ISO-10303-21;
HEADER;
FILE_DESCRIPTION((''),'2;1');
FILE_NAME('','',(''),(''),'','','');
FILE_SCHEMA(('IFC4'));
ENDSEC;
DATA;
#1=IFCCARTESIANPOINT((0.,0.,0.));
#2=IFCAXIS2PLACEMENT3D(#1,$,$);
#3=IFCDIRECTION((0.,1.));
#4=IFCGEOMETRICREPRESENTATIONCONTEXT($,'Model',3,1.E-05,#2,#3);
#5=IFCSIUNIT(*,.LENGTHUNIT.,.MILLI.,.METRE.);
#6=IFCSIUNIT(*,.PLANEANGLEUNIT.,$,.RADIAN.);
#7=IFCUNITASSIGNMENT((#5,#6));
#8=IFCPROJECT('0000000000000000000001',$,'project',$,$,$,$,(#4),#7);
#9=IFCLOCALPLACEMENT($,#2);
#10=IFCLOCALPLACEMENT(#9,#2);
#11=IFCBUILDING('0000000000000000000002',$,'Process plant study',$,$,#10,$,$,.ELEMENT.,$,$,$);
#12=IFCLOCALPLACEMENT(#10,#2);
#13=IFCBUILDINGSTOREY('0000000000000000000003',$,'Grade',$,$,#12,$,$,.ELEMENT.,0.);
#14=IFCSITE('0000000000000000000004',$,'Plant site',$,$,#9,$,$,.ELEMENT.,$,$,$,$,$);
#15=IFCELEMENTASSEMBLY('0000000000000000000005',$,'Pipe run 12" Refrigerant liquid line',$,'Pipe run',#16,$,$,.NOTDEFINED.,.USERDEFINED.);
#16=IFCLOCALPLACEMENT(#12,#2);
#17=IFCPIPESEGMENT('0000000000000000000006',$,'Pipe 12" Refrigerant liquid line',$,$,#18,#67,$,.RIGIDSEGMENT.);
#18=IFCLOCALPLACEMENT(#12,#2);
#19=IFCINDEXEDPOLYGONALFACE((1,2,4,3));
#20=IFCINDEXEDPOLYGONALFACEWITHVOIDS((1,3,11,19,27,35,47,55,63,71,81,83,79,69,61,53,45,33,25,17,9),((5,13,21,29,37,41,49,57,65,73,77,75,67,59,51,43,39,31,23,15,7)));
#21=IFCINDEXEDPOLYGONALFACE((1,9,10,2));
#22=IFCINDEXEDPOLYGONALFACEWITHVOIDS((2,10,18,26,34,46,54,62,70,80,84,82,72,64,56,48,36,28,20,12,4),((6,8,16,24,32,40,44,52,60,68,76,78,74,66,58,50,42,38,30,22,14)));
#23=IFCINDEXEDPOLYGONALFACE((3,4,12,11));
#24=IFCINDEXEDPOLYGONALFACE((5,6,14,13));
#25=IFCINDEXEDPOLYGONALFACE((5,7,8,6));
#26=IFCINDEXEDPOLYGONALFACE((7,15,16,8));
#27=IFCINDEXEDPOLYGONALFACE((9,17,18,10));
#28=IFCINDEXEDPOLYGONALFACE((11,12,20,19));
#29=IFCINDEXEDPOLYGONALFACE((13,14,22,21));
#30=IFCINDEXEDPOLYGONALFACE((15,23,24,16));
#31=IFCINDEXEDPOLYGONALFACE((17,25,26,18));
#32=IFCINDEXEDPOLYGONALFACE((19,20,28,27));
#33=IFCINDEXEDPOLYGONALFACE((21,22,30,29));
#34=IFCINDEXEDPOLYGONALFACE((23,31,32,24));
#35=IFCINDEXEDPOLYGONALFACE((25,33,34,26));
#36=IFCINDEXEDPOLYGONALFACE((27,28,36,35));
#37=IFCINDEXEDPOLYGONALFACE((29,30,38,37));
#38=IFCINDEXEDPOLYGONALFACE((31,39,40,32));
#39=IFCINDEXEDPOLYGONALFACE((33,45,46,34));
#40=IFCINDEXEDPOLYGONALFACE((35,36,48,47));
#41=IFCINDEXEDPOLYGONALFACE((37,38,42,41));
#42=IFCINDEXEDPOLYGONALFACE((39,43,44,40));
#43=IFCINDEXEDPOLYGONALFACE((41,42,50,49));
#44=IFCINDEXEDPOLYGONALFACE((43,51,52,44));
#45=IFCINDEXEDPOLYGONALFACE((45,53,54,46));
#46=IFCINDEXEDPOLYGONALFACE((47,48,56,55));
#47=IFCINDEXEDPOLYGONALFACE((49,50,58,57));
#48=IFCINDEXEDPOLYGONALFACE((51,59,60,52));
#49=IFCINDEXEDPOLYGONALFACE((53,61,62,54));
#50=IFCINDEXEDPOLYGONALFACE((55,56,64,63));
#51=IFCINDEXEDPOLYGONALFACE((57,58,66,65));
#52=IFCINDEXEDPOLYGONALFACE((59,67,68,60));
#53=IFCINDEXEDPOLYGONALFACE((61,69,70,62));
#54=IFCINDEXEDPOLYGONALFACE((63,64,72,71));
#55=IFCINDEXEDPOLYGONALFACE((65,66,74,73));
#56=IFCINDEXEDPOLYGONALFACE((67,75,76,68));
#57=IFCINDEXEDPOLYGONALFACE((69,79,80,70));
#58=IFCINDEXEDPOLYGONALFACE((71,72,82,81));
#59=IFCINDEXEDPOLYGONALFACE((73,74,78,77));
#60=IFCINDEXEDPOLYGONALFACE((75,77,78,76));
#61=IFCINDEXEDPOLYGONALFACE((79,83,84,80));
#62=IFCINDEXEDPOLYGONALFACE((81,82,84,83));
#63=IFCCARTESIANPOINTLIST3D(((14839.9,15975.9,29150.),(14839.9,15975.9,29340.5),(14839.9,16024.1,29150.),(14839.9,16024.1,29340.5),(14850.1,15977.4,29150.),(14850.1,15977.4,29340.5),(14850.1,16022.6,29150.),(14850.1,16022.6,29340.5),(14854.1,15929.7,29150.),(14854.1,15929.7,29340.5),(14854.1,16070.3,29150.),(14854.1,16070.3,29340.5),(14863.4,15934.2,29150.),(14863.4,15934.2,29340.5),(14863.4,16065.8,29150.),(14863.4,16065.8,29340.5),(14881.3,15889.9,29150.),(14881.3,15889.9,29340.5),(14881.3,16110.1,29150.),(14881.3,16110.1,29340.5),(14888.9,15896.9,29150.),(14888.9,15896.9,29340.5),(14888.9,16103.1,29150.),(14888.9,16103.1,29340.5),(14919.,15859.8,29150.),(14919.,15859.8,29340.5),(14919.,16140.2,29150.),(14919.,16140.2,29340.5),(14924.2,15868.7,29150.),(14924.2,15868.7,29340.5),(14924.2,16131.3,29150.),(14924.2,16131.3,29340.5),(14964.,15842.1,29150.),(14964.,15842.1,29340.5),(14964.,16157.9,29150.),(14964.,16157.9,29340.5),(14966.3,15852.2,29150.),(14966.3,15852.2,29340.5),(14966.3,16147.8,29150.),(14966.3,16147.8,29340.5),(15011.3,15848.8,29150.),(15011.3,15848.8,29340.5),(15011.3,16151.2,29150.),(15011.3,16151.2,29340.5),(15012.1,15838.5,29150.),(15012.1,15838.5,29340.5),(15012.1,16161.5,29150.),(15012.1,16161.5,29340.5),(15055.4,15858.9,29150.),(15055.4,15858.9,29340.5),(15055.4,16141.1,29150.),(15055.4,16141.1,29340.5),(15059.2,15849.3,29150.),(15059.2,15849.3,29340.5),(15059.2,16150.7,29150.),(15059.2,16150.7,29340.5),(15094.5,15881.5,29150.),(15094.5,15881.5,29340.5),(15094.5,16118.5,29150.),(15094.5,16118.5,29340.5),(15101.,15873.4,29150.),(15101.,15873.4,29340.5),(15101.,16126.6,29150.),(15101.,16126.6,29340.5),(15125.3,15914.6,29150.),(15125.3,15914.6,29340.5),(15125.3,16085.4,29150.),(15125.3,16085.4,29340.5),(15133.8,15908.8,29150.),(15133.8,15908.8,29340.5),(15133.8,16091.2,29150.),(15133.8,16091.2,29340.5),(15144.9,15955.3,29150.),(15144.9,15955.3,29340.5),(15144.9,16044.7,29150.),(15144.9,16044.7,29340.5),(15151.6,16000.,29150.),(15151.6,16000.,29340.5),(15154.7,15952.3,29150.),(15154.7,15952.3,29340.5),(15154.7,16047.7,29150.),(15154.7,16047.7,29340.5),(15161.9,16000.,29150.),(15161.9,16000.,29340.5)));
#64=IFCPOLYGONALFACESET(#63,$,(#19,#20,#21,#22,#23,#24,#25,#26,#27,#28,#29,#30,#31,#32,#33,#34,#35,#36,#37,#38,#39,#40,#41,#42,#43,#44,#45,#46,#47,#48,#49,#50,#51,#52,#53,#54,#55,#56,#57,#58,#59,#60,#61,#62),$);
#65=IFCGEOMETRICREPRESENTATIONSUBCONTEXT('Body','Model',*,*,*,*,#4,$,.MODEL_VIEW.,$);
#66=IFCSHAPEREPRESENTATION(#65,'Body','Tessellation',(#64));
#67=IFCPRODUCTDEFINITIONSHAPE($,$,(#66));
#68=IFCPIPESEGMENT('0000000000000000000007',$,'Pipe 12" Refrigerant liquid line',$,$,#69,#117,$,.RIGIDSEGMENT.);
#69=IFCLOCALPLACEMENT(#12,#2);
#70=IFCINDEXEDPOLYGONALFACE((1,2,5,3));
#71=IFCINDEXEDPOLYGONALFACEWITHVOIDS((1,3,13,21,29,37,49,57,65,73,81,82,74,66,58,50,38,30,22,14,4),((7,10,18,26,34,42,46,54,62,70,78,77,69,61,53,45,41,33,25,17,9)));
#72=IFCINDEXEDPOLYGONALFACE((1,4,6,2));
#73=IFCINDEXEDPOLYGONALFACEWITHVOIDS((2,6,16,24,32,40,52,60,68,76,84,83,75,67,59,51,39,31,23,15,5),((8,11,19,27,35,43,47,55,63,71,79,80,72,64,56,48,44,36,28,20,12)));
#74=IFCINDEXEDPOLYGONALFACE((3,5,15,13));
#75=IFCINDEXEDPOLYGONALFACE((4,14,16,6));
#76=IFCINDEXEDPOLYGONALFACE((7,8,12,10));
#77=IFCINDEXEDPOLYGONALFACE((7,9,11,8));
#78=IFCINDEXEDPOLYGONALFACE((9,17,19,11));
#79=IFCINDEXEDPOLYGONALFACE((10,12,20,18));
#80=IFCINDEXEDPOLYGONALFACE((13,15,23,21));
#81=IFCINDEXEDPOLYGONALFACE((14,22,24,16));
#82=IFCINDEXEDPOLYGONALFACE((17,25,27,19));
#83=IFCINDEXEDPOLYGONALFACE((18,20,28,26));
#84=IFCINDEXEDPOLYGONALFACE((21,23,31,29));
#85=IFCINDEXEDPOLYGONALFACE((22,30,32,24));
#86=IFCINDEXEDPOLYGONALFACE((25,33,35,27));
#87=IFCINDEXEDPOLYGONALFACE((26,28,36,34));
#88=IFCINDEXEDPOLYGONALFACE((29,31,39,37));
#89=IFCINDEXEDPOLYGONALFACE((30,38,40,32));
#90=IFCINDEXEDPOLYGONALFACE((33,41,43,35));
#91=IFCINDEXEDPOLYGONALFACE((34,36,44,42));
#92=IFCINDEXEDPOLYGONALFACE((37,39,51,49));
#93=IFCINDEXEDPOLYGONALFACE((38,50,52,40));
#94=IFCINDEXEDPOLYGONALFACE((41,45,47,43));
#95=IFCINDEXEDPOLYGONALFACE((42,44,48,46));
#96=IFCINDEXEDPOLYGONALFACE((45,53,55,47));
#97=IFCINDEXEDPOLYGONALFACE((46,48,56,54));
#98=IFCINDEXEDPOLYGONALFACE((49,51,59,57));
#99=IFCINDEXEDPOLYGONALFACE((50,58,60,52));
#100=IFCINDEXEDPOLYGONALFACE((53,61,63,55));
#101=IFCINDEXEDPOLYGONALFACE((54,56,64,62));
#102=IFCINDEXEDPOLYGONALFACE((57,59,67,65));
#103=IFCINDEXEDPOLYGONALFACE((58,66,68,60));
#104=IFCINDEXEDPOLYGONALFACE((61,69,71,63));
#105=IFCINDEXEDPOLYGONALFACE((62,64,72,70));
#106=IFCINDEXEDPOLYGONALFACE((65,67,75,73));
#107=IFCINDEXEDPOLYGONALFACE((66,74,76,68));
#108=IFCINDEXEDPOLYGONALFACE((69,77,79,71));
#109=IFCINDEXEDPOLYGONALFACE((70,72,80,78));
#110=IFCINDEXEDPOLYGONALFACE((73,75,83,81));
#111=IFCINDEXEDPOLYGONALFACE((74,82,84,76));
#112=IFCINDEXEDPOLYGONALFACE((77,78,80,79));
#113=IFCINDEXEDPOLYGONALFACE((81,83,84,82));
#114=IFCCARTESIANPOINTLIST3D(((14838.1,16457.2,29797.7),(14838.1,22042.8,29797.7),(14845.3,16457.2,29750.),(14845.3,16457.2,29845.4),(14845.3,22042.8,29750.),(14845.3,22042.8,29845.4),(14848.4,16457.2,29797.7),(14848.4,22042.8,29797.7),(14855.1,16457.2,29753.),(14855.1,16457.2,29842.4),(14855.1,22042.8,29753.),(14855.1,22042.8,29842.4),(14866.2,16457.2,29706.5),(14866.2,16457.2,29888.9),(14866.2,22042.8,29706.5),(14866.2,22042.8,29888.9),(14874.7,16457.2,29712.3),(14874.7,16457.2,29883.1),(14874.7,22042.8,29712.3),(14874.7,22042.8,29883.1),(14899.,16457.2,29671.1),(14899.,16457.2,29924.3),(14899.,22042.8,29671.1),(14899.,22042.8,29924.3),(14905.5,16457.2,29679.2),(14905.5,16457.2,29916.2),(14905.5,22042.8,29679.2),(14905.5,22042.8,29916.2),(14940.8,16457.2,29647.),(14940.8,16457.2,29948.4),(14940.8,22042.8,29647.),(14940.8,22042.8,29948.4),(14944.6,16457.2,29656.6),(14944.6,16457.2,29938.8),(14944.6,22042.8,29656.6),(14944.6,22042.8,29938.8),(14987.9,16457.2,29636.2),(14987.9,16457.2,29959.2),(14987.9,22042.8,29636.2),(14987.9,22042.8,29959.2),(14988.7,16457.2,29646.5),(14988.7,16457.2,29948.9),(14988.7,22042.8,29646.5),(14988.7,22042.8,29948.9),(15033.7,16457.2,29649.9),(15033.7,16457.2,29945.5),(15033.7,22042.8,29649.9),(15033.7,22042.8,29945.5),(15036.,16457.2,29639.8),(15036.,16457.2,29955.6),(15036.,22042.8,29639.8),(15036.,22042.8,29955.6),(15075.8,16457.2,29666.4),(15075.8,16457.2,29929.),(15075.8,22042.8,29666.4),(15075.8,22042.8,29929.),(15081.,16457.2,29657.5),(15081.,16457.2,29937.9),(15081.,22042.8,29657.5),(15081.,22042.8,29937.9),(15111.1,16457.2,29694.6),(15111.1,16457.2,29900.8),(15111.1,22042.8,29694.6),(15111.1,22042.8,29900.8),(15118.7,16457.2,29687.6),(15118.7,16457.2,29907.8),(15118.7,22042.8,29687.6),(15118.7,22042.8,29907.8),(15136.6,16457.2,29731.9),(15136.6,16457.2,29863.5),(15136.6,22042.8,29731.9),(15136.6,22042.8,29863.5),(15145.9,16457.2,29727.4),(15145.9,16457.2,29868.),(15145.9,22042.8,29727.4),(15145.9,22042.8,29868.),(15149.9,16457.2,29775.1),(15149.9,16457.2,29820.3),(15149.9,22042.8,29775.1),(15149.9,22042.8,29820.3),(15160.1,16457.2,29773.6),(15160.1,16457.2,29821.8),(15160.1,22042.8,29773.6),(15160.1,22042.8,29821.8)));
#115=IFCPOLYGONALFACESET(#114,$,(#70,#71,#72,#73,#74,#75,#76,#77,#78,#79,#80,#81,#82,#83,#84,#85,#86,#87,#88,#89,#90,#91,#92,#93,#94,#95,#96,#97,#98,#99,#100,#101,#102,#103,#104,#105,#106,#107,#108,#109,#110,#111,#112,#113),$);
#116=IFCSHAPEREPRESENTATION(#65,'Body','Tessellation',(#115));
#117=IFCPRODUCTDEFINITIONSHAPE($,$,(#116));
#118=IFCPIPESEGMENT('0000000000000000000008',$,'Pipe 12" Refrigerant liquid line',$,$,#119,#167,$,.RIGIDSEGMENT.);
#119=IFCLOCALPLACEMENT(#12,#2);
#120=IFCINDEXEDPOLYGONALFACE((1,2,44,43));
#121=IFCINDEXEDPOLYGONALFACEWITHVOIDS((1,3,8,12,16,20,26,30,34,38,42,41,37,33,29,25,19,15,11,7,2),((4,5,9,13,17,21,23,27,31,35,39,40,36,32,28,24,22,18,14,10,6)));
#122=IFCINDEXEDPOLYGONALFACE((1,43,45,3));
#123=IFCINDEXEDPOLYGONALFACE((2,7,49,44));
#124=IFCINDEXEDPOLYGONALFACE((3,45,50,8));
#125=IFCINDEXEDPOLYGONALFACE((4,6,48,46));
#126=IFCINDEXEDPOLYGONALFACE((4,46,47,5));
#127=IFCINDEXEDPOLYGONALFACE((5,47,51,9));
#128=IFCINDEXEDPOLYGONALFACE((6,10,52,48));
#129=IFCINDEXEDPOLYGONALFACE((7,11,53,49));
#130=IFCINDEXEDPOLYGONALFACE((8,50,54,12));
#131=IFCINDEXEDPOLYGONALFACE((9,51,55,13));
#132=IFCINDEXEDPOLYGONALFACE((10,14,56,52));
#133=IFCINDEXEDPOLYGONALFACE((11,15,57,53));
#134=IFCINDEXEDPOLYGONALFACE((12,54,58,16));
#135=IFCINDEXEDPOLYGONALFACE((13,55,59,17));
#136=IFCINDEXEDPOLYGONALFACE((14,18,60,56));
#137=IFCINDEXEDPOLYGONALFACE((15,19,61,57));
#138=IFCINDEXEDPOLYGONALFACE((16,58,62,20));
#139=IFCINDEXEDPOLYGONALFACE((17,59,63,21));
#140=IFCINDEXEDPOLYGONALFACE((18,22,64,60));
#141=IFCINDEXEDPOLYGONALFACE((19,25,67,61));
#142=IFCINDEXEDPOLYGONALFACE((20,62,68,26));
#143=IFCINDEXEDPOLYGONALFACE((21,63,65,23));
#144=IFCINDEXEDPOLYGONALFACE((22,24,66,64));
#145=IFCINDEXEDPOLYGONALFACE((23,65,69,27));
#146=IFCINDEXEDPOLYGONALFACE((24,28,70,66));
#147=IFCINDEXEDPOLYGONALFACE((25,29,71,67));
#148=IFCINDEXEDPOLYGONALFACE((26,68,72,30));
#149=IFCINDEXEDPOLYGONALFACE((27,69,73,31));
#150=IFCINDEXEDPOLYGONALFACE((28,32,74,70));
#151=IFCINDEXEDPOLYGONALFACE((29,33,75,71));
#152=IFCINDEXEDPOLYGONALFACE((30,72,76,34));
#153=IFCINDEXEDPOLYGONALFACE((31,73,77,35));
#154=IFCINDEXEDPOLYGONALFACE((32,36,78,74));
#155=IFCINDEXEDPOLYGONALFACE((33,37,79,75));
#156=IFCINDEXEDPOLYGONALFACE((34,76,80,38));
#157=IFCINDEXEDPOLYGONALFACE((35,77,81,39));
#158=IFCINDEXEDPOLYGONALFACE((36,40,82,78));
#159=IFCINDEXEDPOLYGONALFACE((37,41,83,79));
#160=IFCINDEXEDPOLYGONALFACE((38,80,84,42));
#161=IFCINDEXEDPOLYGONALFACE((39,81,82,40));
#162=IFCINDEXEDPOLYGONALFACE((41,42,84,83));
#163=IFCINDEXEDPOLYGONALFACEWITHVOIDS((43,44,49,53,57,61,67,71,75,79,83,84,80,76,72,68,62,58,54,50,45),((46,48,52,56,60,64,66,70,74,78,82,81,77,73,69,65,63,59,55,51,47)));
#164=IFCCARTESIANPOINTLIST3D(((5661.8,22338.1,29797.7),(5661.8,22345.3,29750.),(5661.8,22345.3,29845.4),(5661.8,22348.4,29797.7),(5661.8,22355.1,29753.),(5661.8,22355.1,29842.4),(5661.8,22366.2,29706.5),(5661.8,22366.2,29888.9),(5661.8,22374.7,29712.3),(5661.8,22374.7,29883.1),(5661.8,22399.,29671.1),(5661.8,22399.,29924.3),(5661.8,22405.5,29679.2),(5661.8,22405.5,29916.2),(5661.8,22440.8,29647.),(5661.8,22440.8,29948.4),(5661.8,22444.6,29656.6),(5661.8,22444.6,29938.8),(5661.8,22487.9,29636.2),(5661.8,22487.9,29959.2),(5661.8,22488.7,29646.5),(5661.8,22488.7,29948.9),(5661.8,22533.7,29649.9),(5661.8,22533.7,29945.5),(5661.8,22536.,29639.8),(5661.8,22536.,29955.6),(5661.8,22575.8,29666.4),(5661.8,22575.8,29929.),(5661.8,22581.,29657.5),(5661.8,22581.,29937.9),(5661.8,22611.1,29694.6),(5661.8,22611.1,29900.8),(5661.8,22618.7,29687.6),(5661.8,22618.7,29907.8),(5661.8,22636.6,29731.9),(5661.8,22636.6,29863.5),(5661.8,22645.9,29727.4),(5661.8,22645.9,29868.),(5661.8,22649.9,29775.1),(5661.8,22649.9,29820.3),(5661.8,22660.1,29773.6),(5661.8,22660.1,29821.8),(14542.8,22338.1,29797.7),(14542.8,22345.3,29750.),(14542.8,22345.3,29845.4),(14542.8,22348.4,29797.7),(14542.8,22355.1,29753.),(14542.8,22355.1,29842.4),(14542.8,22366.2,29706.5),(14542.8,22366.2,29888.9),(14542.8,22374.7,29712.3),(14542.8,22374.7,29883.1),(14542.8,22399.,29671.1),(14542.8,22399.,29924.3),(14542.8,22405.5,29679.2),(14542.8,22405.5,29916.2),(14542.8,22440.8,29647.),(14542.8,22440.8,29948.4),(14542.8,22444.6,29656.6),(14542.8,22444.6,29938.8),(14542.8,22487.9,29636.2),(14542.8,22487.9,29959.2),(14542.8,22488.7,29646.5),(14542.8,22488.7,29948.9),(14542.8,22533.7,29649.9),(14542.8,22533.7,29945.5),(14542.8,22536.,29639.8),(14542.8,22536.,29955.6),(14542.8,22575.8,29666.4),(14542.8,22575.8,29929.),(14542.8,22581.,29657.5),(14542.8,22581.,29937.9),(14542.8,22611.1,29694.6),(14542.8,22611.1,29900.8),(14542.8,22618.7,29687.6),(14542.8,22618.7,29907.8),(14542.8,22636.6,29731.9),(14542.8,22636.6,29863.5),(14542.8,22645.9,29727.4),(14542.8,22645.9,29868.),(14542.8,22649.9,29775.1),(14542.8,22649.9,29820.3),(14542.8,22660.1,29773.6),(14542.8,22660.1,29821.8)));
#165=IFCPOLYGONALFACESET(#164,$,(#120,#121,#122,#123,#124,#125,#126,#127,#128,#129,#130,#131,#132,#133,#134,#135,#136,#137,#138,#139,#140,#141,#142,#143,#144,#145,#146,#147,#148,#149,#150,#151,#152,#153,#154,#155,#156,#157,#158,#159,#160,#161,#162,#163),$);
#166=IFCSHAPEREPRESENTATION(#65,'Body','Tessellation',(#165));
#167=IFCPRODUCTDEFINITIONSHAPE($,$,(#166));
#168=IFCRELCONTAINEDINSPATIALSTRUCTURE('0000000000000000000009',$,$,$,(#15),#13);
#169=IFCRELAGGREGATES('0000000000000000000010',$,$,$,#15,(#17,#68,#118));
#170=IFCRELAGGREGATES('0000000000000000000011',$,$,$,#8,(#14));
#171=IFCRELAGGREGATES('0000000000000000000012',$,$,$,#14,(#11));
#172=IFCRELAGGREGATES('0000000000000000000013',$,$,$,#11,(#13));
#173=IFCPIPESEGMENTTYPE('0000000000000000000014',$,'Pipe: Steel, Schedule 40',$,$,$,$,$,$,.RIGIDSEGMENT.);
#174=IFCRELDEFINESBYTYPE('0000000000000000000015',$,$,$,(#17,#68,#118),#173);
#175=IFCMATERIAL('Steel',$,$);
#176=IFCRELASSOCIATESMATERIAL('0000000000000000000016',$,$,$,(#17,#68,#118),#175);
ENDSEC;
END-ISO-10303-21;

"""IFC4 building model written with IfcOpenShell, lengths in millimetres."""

from ifc_helpers import new_model, si_unit, direction, frame, origin, origin_with_axes, origin_2d, place, context, subcontext, project, spatial, hollow_circle, extrude, material, type_object, element, aggregate, save


model = new_model("IFC4")

# Units and contexts
model_context = context("Model", 3, precision=1e-05, world=origin(), true_north=direction((0.0, 1.0)))
body_context = subcontext(model_context, "Body", "Model", "MODEL_VIEW")
ifc_project = project(units=[si_unit("LENGTHUNIT", "METRE", prefix="MILLI"), si_unit("PLANEANGLEUNIT", "RADIAN")], contexts=[model_context])

# Site, building, storey
site_placement = place(None, origin())
site = spatial("IfcSite", under=ifc_project, at=site_placement, Name="Plant site", CompositionType="ELEMENT")
building_placement = place(site_placement, origin())
building = spatial("IfcBuilding", under=site, at=building_placement, Name="Process plant study", CompositionType="ELEMENT")
storey_placement = place(building_placement, origin())
storey = spatial("IfcBuildingStorey", under=building, at=storey_placement, Name="Grade", CompositionType="ELEMENT", Elevation=0.0)

# Element assembly, pipe segments
ifc_material = material(Name="Steel")
pipe_segment_type = type_object("IfcPipeSegmentType", Name="Pipe: Steel, Schedule 40", PredefinedType="RIGIDSEGMENT")
assembly_1_placement = place(storey_placement, origin_with_axes())
assembly_1 = element("IfcElementAssembly", 1, at=assembly_1_placement, inside=storey, Name="Pipe run 12\" Refrigerant liquid line", ObjectType="Pipe run", AssemblyPlace="NOTDEFINED", PredefinedType="USERDEFINED")
pipe_segment_1_placement = place(storey_placement, origin_with_axes())
pipe_segment_1 = element("IfcPipeSegment", 2, at=pipe_segment_1_placement, type_object=pipe_segment_type, material=ifc_material, Name="Pipe 12\" Refrigerant liquid line", PredefinedType="RIGIDSEGMENT", context=body_context, shape_type="SweptSolid", body=[
    extrude(hollow_circle(Radius=161.9, WallThickness=10.3, at=origin_2d()), frame((15000.0, 16000.0, 29150.0), z_axis=(0.0, 0.0, 1.0), x_axis=(1.0, 0.0, 0.0)), (0.0, 0.0, 1.0), 190.5),
])
pipe_segment_2_placement = place(storey_placement, origin_with_axes())
pipe_segment_2 = element("IfcPipeSegment", 3, at=pipe_segment_2_placement, type_object=pipe_segment_type, material=ifc_material, Name="Pipe 12\" Refrigerant liquid line", PredefinedType="RIGIDSEGMENT", context=body_context, shape_type="SweptSolid", body=[
    extrude(hollow_circle(Radius=161.9, WallThickness=10.3, at=origin_2d()), frame((15000.0, 16457.2, 29797.7), z_axis=(0.0, 1.0, 0.0), x_axis=(-1.0, 0.0, 0.0)), (0.0, 0.0, 1.0), 5585.6),
])
pipe_segment_3_placement = place(storey_placement, origin_with_axes())
pipe_segment_3 = element("IfcPipeSegment", 4, at=pipe_segment_3_placement, type_object=pipe_segment_type, material=ifc_material, Name="Pipe 12\" Refrigerant liquid line", PredefinedType="RIGIDSEGMENT", context=body_context, shape_type="SweptSolid", body=[
    extrude(hollow_circle(Radius=161.9, WallThickness=10.3, at=origin_2d()), frame((14542.8, 22500.0, 29797.7), z_axis=(-1.0, 0.0, 0.0), x_axis=(0.0, -1.0, 0.0)), (0.0, 0.0, 1.0), 8881.0),
])

aggregate(assembly_1, [pipe_segment_1, pipe_segment_2, pipe_segment_3])

save(model, "model.ifc")
